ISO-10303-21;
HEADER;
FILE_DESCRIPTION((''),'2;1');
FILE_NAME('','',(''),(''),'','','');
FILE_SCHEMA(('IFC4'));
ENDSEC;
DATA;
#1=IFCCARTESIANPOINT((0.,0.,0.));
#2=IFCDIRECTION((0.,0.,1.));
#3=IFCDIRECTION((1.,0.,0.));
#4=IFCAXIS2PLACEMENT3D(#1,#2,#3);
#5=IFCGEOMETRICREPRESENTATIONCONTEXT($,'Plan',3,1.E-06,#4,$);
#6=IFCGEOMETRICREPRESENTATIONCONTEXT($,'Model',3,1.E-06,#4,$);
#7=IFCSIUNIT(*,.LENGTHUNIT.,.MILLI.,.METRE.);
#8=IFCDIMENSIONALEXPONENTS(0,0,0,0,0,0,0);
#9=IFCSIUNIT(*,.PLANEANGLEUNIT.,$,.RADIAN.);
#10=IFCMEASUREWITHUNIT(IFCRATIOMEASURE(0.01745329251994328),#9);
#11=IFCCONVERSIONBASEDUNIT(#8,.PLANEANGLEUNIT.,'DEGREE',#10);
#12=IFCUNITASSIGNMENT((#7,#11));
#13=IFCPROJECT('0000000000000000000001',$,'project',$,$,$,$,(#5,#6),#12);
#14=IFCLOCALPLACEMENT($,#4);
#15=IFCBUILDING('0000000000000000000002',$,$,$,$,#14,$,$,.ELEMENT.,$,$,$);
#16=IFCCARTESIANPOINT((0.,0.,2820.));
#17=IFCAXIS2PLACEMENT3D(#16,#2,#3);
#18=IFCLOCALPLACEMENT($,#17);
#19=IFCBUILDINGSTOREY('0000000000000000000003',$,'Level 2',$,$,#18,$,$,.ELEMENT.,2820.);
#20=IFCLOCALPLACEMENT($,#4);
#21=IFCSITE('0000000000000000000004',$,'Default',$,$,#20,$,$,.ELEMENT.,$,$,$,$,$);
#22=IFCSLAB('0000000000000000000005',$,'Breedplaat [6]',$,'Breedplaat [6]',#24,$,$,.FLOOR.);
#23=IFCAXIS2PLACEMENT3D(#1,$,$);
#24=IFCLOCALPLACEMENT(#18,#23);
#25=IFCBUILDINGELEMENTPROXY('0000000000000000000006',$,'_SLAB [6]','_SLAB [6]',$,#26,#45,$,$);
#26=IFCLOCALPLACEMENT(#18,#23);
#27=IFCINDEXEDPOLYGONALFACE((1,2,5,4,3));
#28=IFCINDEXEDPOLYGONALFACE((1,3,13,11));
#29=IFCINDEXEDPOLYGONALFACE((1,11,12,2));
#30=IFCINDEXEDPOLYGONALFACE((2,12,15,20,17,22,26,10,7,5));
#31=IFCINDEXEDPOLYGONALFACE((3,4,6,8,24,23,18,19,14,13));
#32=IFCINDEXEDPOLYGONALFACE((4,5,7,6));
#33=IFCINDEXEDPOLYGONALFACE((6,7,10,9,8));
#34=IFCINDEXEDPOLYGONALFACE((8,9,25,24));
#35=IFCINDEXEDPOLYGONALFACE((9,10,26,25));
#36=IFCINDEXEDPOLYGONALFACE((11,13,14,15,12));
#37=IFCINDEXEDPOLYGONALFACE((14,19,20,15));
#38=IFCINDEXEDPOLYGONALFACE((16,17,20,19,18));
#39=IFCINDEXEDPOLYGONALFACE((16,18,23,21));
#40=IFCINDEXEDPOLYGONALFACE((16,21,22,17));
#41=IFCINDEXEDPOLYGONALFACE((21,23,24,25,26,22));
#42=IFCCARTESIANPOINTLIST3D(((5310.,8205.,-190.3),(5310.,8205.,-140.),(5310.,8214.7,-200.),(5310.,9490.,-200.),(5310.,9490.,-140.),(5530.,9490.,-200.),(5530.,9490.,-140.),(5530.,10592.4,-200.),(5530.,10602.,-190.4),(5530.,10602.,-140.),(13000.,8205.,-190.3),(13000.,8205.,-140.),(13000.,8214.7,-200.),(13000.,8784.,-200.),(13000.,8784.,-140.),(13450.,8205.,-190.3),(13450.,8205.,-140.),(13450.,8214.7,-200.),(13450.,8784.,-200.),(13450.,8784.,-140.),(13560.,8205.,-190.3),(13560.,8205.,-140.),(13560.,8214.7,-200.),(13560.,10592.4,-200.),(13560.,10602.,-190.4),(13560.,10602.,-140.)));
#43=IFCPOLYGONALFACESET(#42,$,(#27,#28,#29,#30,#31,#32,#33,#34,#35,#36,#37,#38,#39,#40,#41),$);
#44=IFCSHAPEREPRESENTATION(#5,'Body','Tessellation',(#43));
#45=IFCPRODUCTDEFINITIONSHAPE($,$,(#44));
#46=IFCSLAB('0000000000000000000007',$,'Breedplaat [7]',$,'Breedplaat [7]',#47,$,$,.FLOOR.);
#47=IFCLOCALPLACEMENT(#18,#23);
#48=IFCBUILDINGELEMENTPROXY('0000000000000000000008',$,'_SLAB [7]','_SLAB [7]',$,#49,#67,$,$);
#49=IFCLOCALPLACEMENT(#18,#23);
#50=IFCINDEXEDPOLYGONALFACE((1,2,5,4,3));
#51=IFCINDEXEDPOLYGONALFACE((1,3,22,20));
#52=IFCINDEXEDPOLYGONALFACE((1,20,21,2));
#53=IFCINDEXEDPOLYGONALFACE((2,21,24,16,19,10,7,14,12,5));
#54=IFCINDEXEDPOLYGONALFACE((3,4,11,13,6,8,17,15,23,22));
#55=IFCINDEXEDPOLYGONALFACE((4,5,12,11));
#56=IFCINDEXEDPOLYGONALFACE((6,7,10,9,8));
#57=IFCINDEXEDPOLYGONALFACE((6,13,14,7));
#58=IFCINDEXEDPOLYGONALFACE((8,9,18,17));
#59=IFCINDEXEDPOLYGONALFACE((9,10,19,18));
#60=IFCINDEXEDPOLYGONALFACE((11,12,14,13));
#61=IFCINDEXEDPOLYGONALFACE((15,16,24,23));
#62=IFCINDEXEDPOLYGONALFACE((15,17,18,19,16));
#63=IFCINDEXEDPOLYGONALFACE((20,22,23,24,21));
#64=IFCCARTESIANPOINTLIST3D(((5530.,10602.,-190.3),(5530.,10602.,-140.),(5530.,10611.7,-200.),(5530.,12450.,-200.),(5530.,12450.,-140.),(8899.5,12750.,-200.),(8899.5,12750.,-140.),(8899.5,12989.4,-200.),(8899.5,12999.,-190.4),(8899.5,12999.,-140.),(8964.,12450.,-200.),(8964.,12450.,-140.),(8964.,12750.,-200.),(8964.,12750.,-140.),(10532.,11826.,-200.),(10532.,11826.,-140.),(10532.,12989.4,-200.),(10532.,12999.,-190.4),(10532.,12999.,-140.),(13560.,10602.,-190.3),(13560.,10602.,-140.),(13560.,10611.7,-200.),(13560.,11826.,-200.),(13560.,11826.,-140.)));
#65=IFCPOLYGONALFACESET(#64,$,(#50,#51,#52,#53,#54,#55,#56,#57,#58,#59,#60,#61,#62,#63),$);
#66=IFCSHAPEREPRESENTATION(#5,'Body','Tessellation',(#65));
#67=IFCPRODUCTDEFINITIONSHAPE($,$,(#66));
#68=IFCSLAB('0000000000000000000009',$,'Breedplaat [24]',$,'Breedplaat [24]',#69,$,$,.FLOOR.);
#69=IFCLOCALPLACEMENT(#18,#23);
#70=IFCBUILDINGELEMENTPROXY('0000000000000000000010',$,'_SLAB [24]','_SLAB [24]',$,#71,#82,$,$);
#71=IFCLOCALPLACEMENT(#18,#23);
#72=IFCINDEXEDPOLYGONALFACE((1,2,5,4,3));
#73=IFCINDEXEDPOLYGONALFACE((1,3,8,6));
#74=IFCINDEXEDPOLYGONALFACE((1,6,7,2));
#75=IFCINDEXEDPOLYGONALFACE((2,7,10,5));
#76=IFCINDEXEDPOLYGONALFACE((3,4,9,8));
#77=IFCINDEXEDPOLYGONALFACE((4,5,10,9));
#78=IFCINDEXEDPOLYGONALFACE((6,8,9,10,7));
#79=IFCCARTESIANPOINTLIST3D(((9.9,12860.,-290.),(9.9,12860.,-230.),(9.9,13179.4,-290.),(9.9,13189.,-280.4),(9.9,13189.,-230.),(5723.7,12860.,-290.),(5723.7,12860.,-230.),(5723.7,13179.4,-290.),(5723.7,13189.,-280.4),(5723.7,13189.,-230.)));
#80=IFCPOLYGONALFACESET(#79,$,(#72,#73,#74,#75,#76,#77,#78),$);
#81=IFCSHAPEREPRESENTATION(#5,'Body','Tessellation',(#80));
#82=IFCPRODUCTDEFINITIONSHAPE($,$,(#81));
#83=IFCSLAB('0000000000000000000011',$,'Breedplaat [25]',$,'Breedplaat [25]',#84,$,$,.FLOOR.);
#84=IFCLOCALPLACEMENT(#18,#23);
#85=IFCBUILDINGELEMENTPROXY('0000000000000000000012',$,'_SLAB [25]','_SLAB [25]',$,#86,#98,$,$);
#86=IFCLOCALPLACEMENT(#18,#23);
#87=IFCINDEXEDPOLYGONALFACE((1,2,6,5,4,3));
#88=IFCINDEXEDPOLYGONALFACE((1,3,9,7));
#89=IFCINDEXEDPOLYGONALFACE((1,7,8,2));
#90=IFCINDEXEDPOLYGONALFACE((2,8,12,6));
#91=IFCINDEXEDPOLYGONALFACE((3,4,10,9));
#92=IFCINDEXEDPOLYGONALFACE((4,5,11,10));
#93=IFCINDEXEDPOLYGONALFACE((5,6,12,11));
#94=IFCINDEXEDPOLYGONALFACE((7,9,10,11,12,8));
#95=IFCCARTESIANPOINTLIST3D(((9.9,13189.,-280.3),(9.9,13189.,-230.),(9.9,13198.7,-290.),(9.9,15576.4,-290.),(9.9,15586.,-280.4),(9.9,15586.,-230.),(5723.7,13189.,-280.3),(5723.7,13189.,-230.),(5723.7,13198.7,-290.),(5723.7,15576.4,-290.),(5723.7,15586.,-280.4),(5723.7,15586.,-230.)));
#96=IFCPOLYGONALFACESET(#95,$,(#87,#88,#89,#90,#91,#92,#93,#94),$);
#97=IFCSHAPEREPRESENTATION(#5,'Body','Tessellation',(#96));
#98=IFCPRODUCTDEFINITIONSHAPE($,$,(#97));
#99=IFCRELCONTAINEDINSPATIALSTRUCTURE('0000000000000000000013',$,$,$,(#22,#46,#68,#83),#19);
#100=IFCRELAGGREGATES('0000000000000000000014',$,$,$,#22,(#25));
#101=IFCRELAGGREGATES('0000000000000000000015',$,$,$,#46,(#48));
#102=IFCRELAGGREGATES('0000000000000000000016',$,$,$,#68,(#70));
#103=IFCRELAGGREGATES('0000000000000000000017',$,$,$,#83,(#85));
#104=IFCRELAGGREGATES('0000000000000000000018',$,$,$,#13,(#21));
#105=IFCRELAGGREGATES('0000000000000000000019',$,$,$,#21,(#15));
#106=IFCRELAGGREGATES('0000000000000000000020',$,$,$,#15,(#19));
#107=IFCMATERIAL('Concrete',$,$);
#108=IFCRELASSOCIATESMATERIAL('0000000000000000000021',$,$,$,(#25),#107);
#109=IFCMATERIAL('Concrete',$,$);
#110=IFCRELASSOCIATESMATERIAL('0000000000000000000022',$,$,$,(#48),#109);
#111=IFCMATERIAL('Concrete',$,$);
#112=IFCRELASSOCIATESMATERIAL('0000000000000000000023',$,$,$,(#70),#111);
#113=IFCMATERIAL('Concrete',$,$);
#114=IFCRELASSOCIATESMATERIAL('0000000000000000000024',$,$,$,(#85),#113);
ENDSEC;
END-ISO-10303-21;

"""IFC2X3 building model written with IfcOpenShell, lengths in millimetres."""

from ifc_helpers import new_model, entity, si_unit, converted_unit, frame, origin_with_axes, origin_2d_with_axis, place, context, project, spatial, polyline, rectangle, outline, extrude, material, element, aggregate, save


model = new_model("IFC2X3")

# Units and contexts
plan_context = context("Plan", 3, precision=1e-06, world=origin_with_axes())
model_context = context("Model", 3, precision=1e-06, world=origin_with_axes())
ifc_project = project(units=[si_unit("LENGTHUNIT", "METRE", prefix="MILLI"), converted_unit("PLANEANGLEUNIT", "DEGREE", entity("IfcRatioMeasure", 0.01745329251994328), si_unit("PLANEANGLEUNIT", "RADIAN"), dimensions=[0, 0, 0, 0, 0, 0, 0])], contexts=[plan_context, model_context])

# Site, building, storey
site_placement = place(None, origin_with_axes())
site = spatial("IfcSite", under=ifc_project, at=site_placement, Name="Default", CompositionType="ELEMENT")
building_placement = place(None, origin_with_axes())
building = spatial("IfcBuilding", under=site, at=building_placement, CompositionType="ELEMENT")
storey_placement = place(None, frame((0.0, 0.0, 2820.0), z_axis=(0.0, 0.0, 1.0), x_axis=(1.0, 0.0, 0.0)))
storey = spatial("IfcBuildingStorey", under=building, at=storey_placement, Name="Level 2", CompositionType="ELEMENT", Elevation=2820.0)

# Slabs, building element proxies, openings
slab_1_placement = place(None, frame((5310.0, 8205.0, 2620.0), z_axis=(0.0, 0.0, 1.0), x_axis=(1.0, 0.0, 0.0)))
slab_1 = element("IfcSlab", 1, at=slab_1_placement, inside=storey, Name="Breedplaat [6]", ObjectType="Breedplaat [6]", PredefinedType="FLOOR")
ifc_material_1 = material(Name="Concrete")
proxy_1_placement = place(slab_1_placement, origin_with_axes())
proxy_1 = element("IfcBuildingElementProxy", 2, at=proxy_1_placement, material=ifc_material_1, Name="_SLAB [6]", Description="_SLAB [6]", context=plan_context, shape_type="SweptSolid", body=[
    extrude(outline(polyline([(220.0, 2397.0), (220.0, 1285.0), (0.0, 1285.0), (0.0, 0.0), (8250.0, 0.0), (8250.0, 2397.0), (220.0, 2397.0)])), origin_with_axes(), (0.0, 0.0, 1.0), 60.0),
])
opening_1_placement = place(slab_1_placement, frame((7690.0, 0.0, 0.0), z_axis=(0.0, 0.0, 1.0), x_axis=(1.0, 0.0, 0.0)))
element("IfcOpeningElement", 3, at=opening_1_placement, cuts=proxy_1, ObjectType="Opening", context=plan_context, shape_type="SolidModel", body=[
    extrude(rectangle(XDim=450.0, YDim=579.0, at=origin_2d_with_axis()), frame((225.0, 289.5, 0.0), z_axis=(0.0, 0.0, 1.0), x_axis=(1.0, 0.0, 0.0)), (0.0, 0.0, 1.0), 60.0),
])
opening_2_placement = place(None, frame((5310.0, 8205.0, 2620.0), z_axis=(0.0, 0.0, 1.0), x_axis=(1.0, 0.0, 0.0)))
element("IfcOpeningElement", 4, at=opening_2_placement, cuts=proxy_1, ObjectType="Opening", context=plan_context, shape_type="SweptSolid", body=[
    extrude(outline(polyline([(-0.1, -0.1), (-0.1, 10.0), (10.0, -0.1), (-0.1, -0.1)])), frame((-1.2, -0.1, -0.1), z_axis=(1.0, 0.0, 0.0), x_axis=(0.0, 1.0, 0.0)), (0.0, 0.0, 1.0), 8252.2),
])
opening_3_placement = place(None, frame((5310.0, 8205.0, 2620.0), z_axis=(0.0, 0.0, 1.0), x_axis=(1.0, 0.0, 0.0)))
element("IfcOpeningElement", 5, at=opening_3_placement, cuts=proxy_1, ObjectType="Opening", context=plan_context, shape_type="SweptSolid", body=[
    extrude(outline(polyline([(-0.1, -0.1), (-0.1, 10.0), (10.0, -0.1), (-0.1, -0.1)])), frame((8251.2, 2397.2, -0.1), z_axis=(-1.0, 0.0, 0.0), x_axis=(0.0, -1.0, 0.0)), (0.0, 0.0, 1.0), 8032.2),
])
aggregate(slab_1, [proxy_1])
slab_2_placement = place(None, frame((5530.0, 10602.0, 2620.0), z_axis=(0.0, 0.0, 1.0), x_axis=(1.0, 0.0, 0.0)))
slab_2 = element("IfcSlab", 6, at=slab_2_placement, inside=storey, Name="Breedplaat [7]", ObjectType="Breedplaat [7]", PredefinedType="FLOOR")
ifc_material_2 = material(Name="Concrete")
proxy_2_placement = place(slab_2_placement, origin_with_axes())
proxy_2 = element("IfcBuildingElementProxy", 7, at=proxy_2_placement, material=ifc_material_2, Name="_SLAB [7]", Description="_SLAB [7]", context=plan_context, shape_type="SweptSolid", body=[
    extrude(outline(polyline([(3434.0, 2148.0), (3434.0, 1848.0), (0.0, 1848.0), (0.0, 0.0), (8030.0, 0.0), (8030.0, 1224.0), (5002.0, 1224.0), (5002.0, 2397.0), (3369.5, 2397.0), (3369.5, 2148.0), (3434.0, 2148.0)])), origin_with_axes(), (0.0, 0.0, 1.0), 60.0),
])
opening_4_placement = place(None, frame((5530.0, 10602.0, 2620.0), z_axis=(0.0, 0.0, 1.0), x_axis=(1.0, 0.0, 0.0)))
element("IfcOpeningElement", 8, at=opening_4_placement, cuts=proxy_2, ObjectType="Opening", context=plan_context, shape_type="SweptSolid", body=[
    extrude(outline(polyline([(-0.1, -0.1), (-0.1, 10.0), (10.0, -0.1), (-0.1, -0.1)])), frame((-1.2, -0.1, -0.1), z_axis=(1.0, 0.0, 0.0), x_axis=(0.0, 1.0, 0.0)), (0.0, 0.0, 1.0), 8032.2),
])
opening_5_placement = place(None, frame((5530.0, 10602.0, 2620.0), z_axis=(0.0, 0.0, 1.0), x_axis=(1.0, 0.0, 0.0)))
element("IfcOpeningElement", 9, at=opening_5_placement, cuts=proxy_2, ObjectType="Opening", context=plan_context, shape_type="SweptSolid", body=[
    extrude(outline(polyline([(-0.1, -0.1), (-0.1, 10.0), (10.0, -0.1), (-0.1, -0.1)])), frame((5003.2, 2397.2, -0.1), z_axis=(-1.0, 0.0, 0.0), x_axis=(0.0, -1.0, 0.0)), (0.0, 0.0, 1.0), 1634.7),
])
aggregate(slab_2, [proxy_2])

# Slab, building element proxy, opening
slab_3_placement = place(None, frame((9.9, 12860.0, 2530.0), z_axis=(0.0, 0.0, 1.0), x_axis=(1.0, 0.0, 0.0)))
slab_3 = element("IfcSlab", 10, at=slab_3_placement, inside=storey, Name="Breedplaat [24]", ObjectType="Breedplaat [24]", PredefinedType="FLOOR")
ifc_material_3 = material(Name="Concrete")
proxy_3_placement = place(slab_3_placement, origin_with_axes())
proxy_3 = element("IfcBuildingElementProxy", 11, at=proxy_3_placement, material=ifc_material_3, Name="_SLAB [24]", Description="_SLAB [24]", context=plan_context, shape_type="SweptSolid", body=[
    extrude(outline(polyline([(5713.8, 0.0), (5713.8, 329.0), (0.0, 329.0), (0.0, 0.0), (5713.8, 0.0)])), origin_with_axes(), (0.0, 0.0, 1.0), 60.0),
])
opening_6_placement = place(None, frame((9.9, 12860.0, 2530.0), z_axis=(0.0, 0.0, 1.0), x_axis=(1.0, 0.0, 0.0)))
element("IfcOpeningElement", 12, at=opening_6_placement, cuts=proxy_3, ObjectType="Opening", context=plan_context, shape_type="SweptSolid", body=[
    extrude(outline(polyline([(-0.1, -0.1), (-0.1, 10.0), (10.0, -0.1), (-0.1, -0.1)])), frame((5715.0, 329.2, -0.1), z_axis=(-1.0, 0.0, 0.0), x_axis=(0.0, -1.0, 0.0)), (0.0, 0.0, 1.0), 5716.0),
])
aggregate(slab_3, [proxy_3])

# Slab, building element proxy, openings
slab_4_placement = place(None, frame((9.9, 13189.0, 2530.0), z_axis=(0.0, 0.0, 1.0), x_axis=(1.0, 0.0, 0.0)))
slab_4 = element("IfcSlab", 13, at=slab_4_placement, inside=storey, Name="Breedplaat [25]", ObjectType="Breedplaat [25]", PredefinedType="FLOOR")
ifc_material_4 = material(Name="Concrete")
proxy_4_placement = place(slab_4_placement, origin_with_axes())
proxy_4 = element("IfcBuildingElementProxy", 14, at=proxy_4_placement, material=ifc_material_4, Name="_SLAB [25]", Description="_SLAB [25]", context=plan_context, shape_type="SweptSolid", body=[
    extrude(outline(polyline([(5713.8, 0.0), (5713.8, 2397.0), (0.0, 2397.0), (0.0, 0.0), (5713.8, 0.0)])), origin_with_axes(), (0.0, 0.0, 1.0), 60.0),
])
opening_7_placement = place(None, frame((9.9, 13189.0, 2530.0), z_axis=(0.0, 0.0, 1.0), x_axis=(1.0, 0.0, 0.0)))
element("IfcOpeningElement", 15, at=opening_7_placement, cuts=proxy_4, ObjectType="Opening", context=plan_context, shape_type="SweptSolid", body=[
    extrude(outline(polyline([(-0.1, -0.1), (-0.1, 10.0), (10.0, -0.1), (-0.1, -0.1)])), frame((-1.2, -0.1, -0.1), z_axis=(1.0, 0.0, 0.0), x_axis=(0.0, 1.0, 0.0)), (0.0, 0.0, 1.0), 5716.0),
])
opening_8_placement = place(None, frame((9.9, 13189.0, 2530.0), z_axis=(0.0, 0.0, 1.0), x_axis=(1.0, 0.0, 0.0)))
element("IfcOpeningElement", 16, at=opening_8_placement, cuts=proxy_4, ObjectType="Opening", context=plan_context, shape_type="SweptSolid", body=[
    extrude(outline(polyline([(-0.1, -0.1), (-0.1, 10.0), (10.0, -0.1), (-0.1, -0.1)])), frame((5715.0, 2397.2, -0.1), z_axis=(-1.0, 0.0, 0.0), x_axis=(0.0, -1.0, 0.0)), (0.0, 0.0, 1.0), 5716.0),
])
aggregate(slab_4, [proxy_4])

save(model, "model.ifc")
